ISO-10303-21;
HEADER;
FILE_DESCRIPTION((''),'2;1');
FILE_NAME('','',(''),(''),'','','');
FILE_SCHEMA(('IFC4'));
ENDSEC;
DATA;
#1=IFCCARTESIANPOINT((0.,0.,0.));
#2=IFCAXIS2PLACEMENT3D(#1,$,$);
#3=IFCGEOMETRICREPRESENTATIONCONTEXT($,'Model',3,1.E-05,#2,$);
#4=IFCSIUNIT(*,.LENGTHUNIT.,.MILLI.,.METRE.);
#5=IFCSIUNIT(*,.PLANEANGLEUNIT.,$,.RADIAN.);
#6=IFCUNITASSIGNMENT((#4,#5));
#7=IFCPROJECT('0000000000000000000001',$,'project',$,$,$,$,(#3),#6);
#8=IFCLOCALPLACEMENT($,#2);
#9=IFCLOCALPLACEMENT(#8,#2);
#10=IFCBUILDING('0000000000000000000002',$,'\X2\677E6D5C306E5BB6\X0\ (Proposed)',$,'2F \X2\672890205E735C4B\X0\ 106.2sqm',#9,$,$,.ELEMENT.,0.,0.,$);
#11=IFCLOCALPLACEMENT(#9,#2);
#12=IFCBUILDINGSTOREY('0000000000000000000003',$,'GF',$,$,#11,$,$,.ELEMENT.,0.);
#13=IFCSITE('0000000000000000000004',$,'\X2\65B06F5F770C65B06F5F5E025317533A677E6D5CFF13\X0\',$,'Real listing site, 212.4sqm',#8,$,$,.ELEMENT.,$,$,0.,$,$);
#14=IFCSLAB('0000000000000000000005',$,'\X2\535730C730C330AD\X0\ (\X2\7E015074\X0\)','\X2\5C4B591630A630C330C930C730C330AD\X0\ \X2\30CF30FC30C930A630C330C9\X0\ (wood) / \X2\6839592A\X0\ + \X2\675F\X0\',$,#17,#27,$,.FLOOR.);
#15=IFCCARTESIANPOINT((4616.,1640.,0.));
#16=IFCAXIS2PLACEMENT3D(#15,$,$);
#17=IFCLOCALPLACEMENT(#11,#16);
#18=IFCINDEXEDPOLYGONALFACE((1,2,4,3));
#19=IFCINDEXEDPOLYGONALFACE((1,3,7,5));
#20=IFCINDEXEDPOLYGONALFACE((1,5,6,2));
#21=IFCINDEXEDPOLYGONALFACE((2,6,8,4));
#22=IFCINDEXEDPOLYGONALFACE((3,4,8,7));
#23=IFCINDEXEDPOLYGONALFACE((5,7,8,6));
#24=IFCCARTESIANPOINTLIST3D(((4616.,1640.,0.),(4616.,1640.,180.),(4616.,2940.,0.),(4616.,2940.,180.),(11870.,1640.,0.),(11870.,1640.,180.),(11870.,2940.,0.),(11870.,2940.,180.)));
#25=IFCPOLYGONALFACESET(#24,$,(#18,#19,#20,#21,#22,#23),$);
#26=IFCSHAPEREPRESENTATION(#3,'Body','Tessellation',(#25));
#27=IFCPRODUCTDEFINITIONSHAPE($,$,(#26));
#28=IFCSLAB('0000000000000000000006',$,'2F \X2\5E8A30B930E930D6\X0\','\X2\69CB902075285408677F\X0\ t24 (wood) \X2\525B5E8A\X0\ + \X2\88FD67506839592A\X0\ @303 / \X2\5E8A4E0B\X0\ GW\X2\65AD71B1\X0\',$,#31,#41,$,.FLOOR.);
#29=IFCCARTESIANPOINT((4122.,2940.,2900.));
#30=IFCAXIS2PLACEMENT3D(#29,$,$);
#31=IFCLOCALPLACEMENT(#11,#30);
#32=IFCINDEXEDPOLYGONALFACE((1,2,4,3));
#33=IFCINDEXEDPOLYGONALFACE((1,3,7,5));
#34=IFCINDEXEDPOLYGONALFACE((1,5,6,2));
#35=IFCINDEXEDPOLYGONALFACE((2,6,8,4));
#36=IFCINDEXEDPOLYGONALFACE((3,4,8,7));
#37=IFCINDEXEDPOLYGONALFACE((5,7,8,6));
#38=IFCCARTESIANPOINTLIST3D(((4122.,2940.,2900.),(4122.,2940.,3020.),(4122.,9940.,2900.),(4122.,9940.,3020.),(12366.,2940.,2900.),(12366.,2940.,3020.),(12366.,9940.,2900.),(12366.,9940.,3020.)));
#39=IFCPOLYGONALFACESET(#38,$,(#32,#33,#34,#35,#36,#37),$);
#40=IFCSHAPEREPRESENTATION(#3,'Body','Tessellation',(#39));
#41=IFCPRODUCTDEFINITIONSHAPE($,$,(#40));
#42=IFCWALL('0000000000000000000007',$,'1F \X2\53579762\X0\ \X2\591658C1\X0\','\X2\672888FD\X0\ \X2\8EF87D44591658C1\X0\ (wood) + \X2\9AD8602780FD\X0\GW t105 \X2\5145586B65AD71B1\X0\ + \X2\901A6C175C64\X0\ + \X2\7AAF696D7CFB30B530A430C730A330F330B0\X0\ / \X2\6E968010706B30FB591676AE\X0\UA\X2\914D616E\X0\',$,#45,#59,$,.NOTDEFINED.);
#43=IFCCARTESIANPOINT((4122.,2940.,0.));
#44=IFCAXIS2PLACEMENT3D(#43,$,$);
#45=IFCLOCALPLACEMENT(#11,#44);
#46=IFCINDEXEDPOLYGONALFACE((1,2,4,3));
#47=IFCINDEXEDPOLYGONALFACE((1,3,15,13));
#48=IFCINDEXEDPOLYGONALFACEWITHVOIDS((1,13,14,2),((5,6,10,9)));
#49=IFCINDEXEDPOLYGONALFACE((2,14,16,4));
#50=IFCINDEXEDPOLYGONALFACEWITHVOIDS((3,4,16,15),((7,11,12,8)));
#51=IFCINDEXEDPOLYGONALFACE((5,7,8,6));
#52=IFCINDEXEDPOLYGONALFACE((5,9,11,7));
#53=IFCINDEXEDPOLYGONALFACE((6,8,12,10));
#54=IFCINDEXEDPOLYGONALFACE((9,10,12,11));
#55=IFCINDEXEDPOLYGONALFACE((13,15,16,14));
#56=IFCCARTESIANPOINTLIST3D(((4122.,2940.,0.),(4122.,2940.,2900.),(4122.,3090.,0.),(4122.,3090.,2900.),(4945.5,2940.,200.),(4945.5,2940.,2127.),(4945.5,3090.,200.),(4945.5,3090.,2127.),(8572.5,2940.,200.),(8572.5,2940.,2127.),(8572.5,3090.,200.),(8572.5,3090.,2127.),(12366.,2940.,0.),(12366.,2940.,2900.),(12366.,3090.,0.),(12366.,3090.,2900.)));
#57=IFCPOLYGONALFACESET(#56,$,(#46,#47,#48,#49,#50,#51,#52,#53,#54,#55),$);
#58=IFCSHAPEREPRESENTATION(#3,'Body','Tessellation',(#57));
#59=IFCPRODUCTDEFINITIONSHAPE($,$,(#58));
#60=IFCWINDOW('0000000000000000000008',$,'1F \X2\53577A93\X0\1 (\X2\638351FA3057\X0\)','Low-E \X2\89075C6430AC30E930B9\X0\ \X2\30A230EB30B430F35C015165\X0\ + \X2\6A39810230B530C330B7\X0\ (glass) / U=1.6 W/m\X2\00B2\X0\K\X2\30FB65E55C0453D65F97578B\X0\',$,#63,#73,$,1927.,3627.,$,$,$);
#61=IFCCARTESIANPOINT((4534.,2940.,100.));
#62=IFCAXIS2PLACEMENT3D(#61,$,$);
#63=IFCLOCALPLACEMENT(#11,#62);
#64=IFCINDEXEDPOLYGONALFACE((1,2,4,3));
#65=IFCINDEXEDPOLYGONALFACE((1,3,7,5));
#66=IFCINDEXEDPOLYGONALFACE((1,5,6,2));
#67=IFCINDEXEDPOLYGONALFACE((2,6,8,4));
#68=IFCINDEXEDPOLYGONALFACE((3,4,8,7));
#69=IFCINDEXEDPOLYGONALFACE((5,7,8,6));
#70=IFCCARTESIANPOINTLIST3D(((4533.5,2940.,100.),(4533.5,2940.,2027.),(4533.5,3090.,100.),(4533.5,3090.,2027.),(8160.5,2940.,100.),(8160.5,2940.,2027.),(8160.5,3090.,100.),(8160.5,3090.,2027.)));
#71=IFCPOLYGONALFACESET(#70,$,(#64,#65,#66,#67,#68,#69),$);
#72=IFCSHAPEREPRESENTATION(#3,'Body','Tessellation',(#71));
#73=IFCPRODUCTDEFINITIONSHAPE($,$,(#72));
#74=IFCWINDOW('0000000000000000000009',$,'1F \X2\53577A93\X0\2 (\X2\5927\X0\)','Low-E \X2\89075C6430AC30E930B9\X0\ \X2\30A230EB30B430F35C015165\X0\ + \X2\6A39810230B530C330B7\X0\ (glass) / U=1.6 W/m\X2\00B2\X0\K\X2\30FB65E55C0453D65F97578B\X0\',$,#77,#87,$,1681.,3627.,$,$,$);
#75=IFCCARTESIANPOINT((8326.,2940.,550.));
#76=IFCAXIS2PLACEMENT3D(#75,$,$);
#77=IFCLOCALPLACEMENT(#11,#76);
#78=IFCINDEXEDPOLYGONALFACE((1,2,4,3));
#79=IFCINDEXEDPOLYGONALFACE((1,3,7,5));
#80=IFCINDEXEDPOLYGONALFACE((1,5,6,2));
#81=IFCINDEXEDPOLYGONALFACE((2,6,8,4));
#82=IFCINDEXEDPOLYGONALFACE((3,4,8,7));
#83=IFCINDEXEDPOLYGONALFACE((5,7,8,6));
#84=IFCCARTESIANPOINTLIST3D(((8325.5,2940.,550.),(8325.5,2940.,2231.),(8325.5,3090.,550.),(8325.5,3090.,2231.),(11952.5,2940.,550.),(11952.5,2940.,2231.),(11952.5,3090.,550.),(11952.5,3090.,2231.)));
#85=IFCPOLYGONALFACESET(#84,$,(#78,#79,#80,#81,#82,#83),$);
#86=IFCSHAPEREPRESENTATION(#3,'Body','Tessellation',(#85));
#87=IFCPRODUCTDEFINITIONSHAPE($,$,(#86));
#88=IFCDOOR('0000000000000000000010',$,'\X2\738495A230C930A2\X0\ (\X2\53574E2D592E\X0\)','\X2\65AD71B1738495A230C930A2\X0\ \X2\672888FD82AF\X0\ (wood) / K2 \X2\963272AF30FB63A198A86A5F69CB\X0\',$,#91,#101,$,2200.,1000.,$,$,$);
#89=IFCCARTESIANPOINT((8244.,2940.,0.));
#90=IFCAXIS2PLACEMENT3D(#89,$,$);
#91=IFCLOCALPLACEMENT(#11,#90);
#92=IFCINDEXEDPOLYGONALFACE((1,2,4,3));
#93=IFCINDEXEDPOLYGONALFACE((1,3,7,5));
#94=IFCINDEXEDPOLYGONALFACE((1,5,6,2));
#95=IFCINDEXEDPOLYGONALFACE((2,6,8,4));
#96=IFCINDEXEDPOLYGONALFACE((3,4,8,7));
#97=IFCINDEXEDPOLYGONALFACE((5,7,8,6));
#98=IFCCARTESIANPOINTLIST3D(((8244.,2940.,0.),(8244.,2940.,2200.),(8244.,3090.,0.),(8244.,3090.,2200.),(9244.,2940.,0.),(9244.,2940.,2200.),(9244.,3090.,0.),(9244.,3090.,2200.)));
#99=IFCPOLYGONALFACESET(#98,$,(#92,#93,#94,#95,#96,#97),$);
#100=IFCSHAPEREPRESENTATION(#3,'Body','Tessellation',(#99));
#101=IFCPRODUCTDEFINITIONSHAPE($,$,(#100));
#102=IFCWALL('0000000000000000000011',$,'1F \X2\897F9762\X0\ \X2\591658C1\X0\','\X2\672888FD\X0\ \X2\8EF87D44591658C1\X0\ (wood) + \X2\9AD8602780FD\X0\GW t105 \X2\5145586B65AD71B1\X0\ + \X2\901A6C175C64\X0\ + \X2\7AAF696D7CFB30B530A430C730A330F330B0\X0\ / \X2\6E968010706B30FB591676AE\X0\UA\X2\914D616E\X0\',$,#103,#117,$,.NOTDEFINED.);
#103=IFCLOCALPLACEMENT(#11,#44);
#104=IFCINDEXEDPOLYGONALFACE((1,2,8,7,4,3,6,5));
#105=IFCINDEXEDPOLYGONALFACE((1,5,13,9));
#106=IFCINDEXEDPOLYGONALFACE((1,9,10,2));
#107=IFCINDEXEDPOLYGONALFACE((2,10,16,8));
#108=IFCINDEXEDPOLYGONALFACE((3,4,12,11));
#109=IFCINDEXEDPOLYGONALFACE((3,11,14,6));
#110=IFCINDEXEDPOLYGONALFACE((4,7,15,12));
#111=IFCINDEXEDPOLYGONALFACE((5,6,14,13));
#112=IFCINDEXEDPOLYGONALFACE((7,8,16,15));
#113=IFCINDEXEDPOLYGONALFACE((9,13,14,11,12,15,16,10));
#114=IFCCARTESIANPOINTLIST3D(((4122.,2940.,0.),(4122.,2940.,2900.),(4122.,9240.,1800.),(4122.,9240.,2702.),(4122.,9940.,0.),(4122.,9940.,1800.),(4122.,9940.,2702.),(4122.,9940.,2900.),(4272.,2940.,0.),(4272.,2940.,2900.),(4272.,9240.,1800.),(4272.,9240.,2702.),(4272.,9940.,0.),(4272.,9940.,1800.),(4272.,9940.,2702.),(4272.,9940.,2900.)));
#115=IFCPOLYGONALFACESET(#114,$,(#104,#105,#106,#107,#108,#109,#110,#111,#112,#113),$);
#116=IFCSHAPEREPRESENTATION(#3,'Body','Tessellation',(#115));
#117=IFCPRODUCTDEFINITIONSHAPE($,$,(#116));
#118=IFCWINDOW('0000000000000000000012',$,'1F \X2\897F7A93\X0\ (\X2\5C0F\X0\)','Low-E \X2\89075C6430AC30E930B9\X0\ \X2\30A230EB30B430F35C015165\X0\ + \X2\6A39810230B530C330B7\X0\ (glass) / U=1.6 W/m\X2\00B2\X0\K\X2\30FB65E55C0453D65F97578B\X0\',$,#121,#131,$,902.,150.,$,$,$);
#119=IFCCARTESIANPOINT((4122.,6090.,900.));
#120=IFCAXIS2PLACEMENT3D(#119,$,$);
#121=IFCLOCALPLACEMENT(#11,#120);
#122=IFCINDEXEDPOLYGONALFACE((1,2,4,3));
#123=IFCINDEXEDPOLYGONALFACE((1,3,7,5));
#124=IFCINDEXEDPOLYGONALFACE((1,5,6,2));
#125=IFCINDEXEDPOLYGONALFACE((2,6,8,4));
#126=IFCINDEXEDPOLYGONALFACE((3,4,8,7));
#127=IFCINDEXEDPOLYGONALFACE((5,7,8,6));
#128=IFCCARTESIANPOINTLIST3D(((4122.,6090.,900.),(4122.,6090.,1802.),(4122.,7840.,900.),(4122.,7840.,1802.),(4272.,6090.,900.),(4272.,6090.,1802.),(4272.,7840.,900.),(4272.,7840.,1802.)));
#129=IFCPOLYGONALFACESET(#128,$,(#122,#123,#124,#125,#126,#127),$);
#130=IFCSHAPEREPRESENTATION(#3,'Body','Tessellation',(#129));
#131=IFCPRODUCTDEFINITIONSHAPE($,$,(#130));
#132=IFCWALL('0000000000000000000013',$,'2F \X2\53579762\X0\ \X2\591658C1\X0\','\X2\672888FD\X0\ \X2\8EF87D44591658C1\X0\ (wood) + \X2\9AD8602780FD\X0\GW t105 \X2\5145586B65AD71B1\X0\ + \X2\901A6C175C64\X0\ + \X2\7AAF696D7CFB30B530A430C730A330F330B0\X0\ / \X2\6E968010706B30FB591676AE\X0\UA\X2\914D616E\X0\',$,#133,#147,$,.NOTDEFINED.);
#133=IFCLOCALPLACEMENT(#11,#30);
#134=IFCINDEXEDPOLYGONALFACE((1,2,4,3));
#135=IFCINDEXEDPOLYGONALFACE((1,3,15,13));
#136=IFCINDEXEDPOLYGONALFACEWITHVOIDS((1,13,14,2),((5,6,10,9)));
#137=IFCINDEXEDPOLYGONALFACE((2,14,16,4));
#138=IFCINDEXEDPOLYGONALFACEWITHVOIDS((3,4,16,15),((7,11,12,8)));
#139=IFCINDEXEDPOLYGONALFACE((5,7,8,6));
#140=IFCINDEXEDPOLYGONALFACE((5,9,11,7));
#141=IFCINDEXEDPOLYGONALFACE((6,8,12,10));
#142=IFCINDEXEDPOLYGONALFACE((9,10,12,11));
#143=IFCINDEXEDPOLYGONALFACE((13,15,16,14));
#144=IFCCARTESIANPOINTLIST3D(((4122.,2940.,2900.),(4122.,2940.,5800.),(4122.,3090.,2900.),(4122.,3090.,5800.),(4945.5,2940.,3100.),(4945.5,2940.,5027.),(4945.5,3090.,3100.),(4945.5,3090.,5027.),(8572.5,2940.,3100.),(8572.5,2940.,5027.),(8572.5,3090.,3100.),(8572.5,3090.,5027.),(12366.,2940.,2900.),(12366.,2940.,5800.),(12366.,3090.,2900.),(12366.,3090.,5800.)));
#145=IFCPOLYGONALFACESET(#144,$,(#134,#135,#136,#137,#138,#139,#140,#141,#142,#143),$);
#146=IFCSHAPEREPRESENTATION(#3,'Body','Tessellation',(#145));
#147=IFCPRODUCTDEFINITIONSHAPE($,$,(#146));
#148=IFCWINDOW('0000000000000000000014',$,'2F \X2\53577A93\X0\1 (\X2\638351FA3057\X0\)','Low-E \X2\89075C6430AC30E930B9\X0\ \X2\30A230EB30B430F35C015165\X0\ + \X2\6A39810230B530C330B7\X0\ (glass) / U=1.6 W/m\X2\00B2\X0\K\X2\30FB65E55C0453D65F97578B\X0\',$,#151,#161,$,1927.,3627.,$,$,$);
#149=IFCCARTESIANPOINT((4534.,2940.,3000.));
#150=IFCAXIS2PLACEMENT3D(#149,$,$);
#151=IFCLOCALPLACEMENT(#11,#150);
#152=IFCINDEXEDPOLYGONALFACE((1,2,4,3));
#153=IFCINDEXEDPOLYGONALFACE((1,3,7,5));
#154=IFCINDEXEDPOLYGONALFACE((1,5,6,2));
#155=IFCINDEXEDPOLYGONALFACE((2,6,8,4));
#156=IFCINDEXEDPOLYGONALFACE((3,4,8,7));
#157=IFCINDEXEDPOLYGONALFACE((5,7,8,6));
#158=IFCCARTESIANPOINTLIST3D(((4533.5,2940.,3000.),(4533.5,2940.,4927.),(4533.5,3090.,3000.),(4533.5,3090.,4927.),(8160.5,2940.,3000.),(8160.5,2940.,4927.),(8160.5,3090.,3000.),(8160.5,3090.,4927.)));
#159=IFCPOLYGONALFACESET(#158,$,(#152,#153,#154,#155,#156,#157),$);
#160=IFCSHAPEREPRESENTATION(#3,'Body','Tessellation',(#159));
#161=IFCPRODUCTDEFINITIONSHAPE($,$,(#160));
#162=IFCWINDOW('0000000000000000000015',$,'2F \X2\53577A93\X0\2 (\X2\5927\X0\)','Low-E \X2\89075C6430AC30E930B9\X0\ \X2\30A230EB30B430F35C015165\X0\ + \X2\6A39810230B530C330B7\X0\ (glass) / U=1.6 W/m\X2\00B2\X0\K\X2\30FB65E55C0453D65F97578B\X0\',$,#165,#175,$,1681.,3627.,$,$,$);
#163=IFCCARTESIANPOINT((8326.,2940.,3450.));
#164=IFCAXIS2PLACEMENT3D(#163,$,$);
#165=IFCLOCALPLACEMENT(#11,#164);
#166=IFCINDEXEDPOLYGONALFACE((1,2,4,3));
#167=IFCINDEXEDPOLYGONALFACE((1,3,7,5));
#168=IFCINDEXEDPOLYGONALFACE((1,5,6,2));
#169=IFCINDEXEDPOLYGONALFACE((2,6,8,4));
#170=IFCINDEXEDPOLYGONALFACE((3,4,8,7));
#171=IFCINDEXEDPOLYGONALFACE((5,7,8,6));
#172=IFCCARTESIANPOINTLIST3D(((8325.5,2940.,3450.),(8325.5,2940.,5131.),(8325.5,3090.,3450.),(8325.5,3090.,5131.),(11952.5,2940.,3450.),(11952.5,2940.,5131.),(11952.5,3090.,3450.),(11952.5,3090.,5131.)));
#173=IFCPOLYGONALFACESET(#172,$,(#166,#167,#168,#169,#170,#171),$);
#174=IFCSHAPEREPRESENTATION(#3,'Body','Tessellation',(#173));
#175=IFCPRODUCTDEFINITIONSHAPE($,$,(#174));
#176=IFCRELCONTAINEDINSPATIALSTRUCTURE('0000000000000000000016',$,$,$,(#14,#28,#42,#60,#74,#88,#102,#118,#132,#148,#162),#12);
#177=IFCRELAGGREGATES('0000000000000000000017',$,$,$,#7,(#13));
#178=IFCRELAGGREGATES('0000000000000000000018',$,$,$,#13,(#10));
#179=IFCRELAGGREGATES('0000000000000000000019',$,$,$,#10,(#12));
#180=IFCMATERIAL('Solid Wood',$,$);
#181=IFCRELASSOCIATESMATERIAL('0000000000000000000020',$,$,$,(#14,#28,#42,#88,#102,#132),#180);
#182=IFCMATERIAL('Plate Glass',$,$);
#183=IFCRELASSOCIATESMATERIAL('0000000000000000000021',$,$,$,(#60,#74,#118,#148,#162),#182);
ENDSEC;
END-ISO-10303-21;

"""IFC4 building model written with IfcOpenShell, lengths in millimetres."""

from ifc_helpers import new_model, si_unit, frame, frame_2d, origin, place, context, project, spatial, rectangle, extrude, material, element, fill, save


model = new_model("IFC4")

# Units and contexts
model_context = context("Model", 3, precision=1e-05, world=origin())
ifc_project = project(units=[si_unit("LENGTHUNIT", "METRE", prefix="MILLI"), si_unit("PLANEANGLEUNIT", "RADIAN")], contexts=[model_context])

# Site, building, storey
site_placement = place(None, origin())
site = spatial("IfcSite", under=ifc_project, at=site_placement, Name="新潟県新潟市北区松浜３", ObjectType="Real listing site, 212.4sqm", CompositionType="ELEMENT", RefElevation=0.0)
building_placement = place(site_placement, origin())
building = spatial("IfcBuilding", under=site, at=building_placement, Name="松浜の家 (Proposed)", ObjectType="2F 木造平屋 106.2sqm", CompositionType="ELEMENT", ElevationOfRefHeight=0.0, ElevationOfTerrain=0.0)
storey_placement = place(building_placement, origin())
storey = spatial("IfcBuildingStorey", under=building, at=storey_placement, Name="GF", CompositionType="ELEMENT", Elevation=0.0)

# Slabs
ifc_material_1 = material(Name="Solid Wood")
slab_1_placement = place(storey_placement, frame((4616.0, 1640.0, 0.0)))
element("IfcSlab", 1, at=slab_1_placement, inside=storey, material=ifc_material_1, Name="南デッキ (縁側)", Description="屋外ウッドデッキ ハードウッド (wood) / 根太 + 束", PredefinedType="FLOOR", context=model_context, shape_type="SweptSolid", body=[
    extrude(rectangle(XDim=7254.0, YDim=1300.0, at=frame_2d((3627.0, 650.0))), frame((4616.0, 1640.0, 0.0)), (0.0, 0.0, 1.0), 180.0),
])
slab_2_placement = place(storey_placement, frame((4122.0, 2940.0, 2900.0)))
element("IfcSlab", 2, at=slab_2_placement, inside=storey, material=ifc_material_1, Name="2F 床スラブ", Description="構造用合板 t24 (wood) 剛床 + 製材根太 @303 / 床下 GW断熱", PredefinedType="FLOOR", context=model_context, shape_type="SweptSolid", body=[
    extrude(rectangle(XDim=8244.0, YDim=7000.0, at=frame_2d((4122.0, 3500.0))), frame((4122.0, 2940.0, 2900.0)), (0.0, 0.0, 1.0), 120.0),
])

# Wall, openings, windows, door
wall_1_placement = place(storey_placement, frame((4122.0, 2940.0, 0.0)))
wall_1 = element("IfcWall", 3, at=wall_1_placement, inside=storey, material=ifc_material_1, Name="1F 南面 外壁", Description="木製 軸組外壁 (wood) + 高性能GW t105 充填断熱 + 通気層 + 窯業系サイディング / 準耐火・外皮UA配慮", PredefinedType="NOTDEFINED", context=model_context, shape_type="SweptSolid", body=[
    extrude(rectangle(XDim=8244.0, YDim=150.0, at=frame_2d((4122.0, 75.0))), frame((4122.0, 2940.0, 0.0)), (0.0, 0.0, 1.0), 2900.0),
])
opening_1_placement = place(storey_placement, frame((4534.0, 2940.0, 100.0)))
opening_1 = element("IfcOpeningElement", 4, at=opening_1_placement, cuts=wall_1, PredefinedType="NOTDEFINED", context=model_context, shape_type="SweptSolid", body=[
    extrude(rectangle(XDim=3627.0, YDim=150.0, at=frame_2d((1813.0, 75.0))), frame((4534.0, 2940.0, 100.0)), (0.0, 0.0, 1.0), 1927.0),
])
opening_2_placement = place(storey_placement, frame((8326.0, 2940.0, 550.0)))
opening_2 = element("IfcOpeningElement", 5, at=opening_2_placement, cuts=wall_1, PredefinedType="NOTDEFINED", context=model_context, shape_type="SweptSolid", body=[
    extrude(rectangle(XDim=3627.0, YDim=150.0, at=frame_2d((1813.0, 75.0))), frame((8326.0, 2940.0, 550.0)), (0.0, 0.0, 1.0), 1681.0),
])
opening_3_placement = place(storey_placement, frame((8244.0, 2940.0, 0.0)))
opening_3 = element("IfcOpeningElement", 6, at=opening_3_placement, cuts=wall_1, PredefinedType="NOTDEFINED", context=model_context, shape_type="SweptSolid", body=[
    extrude(rectangle(XDim=1000.0, YDim=150.0, at=frame_2d((500.0, 75.0))), frame((8244.0, 2940.0, 0.0)), (0.0, 0.0, 1.0), 2200.0),
])
ifc_material_2 = material(Name="Plate Glass")
window_1_placement = place(storey_placement, frame((4534.0, 2940.0, 100.0)))
window_1 = element("IfcWindow", 7, at=window_1_placement, inside=storey, material=ifc_material_2, Name="1F 南窓1 (掃出し)", Description="Low-E 複層ガラス アルゴン封入 + 樹脂サッシ (glass) / U=1.6 W/m²K・日射取得型", OverallHeight=1927.0, OverallWidth=3627.0, context=model_context, shape_type="SweptSolid", body=[
    extrude(rectangle(XDim=3627.0, YDim=150.0, at=frame_2d((1813.0, 75.0))), frame((4534.0, 2940.0, 100.0)), (0.0, 0.0, 1.0), 1927.0),
])
fill(opening_1, window_1)
window_2_placement = place(storey_placement, frame((8326.0, 2940.0, 550.0)))
window_2 = element("IfcWindow", 8, at=window_2_placement, inside=storey, material=ifc_material_2, Name="1F 南窓2 (大)", Description="Low-E 複層ガラス アルゴン封入 + 樹脂サッシ (glass) / U=1.6 W/m²K・日射取得型", OverallHeight=1681.0, OverallWidth=3627.0, context=model_context, shape_type="SweptSolid", body=[
    extrude(rectangle(XDim=3627.0, YDim=150.0, at=frame_2d((1813.0, 75.0))), frame((8326.0, 2940.0, 550.0)), (0.0, 0.0, 1.0), 1681.0),
])
fill(opening_2, window_2)
door_placement = place(storey_placement, frame((8244.0, 2940.0, 0.0)))
door = element("IfcDoor", 9, at=door_placement, inside=storey, material=ifc_material_1, Name="玄関ドア (南中央)", Description="断熱玄関ドア 木製芯 (wood) / K2 防犯・採風機構", OverallHeight=2200.0, OverallWidth=1000.0, context=model_context, shape_type="SweptSolid", body=[
    extrude(rectangle(XDim=1000.0, YDim=150.0, at=frame_2d((500.0, 75.0))), frame((8244.0, 2940.0, 0.0)), (0.0, 0.0, 1.0), 2200.0),
])
fill(opening_3, door)

# Wall, opening, window
wall_2_placement = place(storey_placement, frame((4122.0, 2940.0, 0.0)))
wall_2 = element("IfcWall", 10, at=wall_2_placement, inside=storey, material=ifc_material_1, Name="1F 西面 外壁", Description="木製 軸組外壁 (wood) + 高性能GW t105 充填断熱 + 通気層 + 窯業系サイディング / 準耐火・外皮UA配慮", PredefinedType="NOTDEFINED", context=model_context, shape_type="SweptSolid", body=[
    extrude(rectangle(XDim=150.0, YDim=7000.0, at=frame_2d((75.0, 3500.0))), frame((4122.0, 2940.0, 0.0)), (0.0, 0.0, 1.0), 2900.0),
])
opening_4_placement = place(storey_placement, frame((4122.0, 6090.0, 900.0)))
opening_4 = element("IfcOpeningElement", 11, at=opening_4_placement, cuts=wall_2, PredefinedType="NOTDEFINED", context=model_context, shape_type="SweptSolid", body=[
    extrude(rectangle(XDim=150.0, YDim=1750.0, at=frame_2d((75.0, 875.0))), frame((4122.0, 6090.0, 900.0)), (0.0, 0.0, 1.0), 902.0),
])
window_3_placement = place(storey_placement, frame((4122.0, 6090.0, 900.0)))
window_3 = element("IfcWindow", 12, at=window_3_placement, inside=storey, material=ifc_material_2, Name="1F 西窓 (小)", Description="Low-E 複層ガラス アルゴン封入 + 樹脂サッシ (glass) / U=1.6 W/m²K・日射取得型", OverallHeight=902.0, OverallWidth=150.0, context=model_context, shape_type="SweptSolid", body=[
    extrude(rectangle(XDim=150.0, YDim=1750.0, at=frame_2d((75.0, 875.0))), frame((4122.0, 6090.0, 900.0)), (0.0, 0.0, 1.0), 902.0),
])
fill(opening_4, window_3)

# Wall, openings, windows
wall_3_placement = place(storey_placement, frame((4122.0, 2940.0, 2900.0)))
wall_3 = element("IfcWall", 13, at=wall_3_placement, inside=storey, material=ifc_material_1, Name="2F 南面 外壁", Description="木製 軸組外壁 (wood) + 高性能GW t105 充填断熱 + 通気層 + 窯業系サイディング / 準耐火・外皮UA配慮", PredefinedType="NOTDEFINED", context=model_context, shape_type="SweptSolid", body=[
    extrude(rectangle(XDim=8244.0, YDim=150.0, at=frame_2d((4122.0, 75.0))), frame((4122.0, 2940.0, 2900.0)), (0.0, 0.0, 1.0), 2900.0),
])
opening_5_placement = place(storey_placement, frame((4534.0, 2940.0, 3000.0)))
opening_5 = element("IfcOpeningElement", 14, at=opening_5_placement, cuts=wall_3, PredefinedType="NOTDEFINED", context=model_context, shape_type="SweptSolid", body=[
    extrude(rectangle(XDim=3627.0, YDim=150.0, at=frame_2d((1813.0, 75.0))), frame((4534.0, 2940.0, 3000.0)), (0.0, 0.0, 1.0), 1927.0),
])
opening_6_placement = place(storey_placement, frame((8326.0, 2940.0, 3450.0)))
opening_6 = element("IfcOpeningElement", 15, at=opening_6_placement, cuts=wall_3, PredefinedType="NOTDEFINED", context=model_context, shape_type="SweptSolid", body=[
    extrude(rectangle(XDim=3627.0, YDim=150.0, at=frame_2d((1813.0, 75.0))), frame((8326.0, 2940.0, 3450.0)), (0.0, 0.0, 1.0), 1681.0),
])
window_4_placement = place(storey_placement, frame((4534.0, 2940.0, 3000.0)))
window_4 = element("IfcWindow", 16, at=window_4_placement, inside=storey, material=ifc_material_2, Name="2F 南窓1 (掃出し)", Description="Low-E 複層ガラス アルゴン封入 + 樹脂サッシ (glass) / U=1.6 W/m²K・日射取得型", OverallHeight=1927.0, OverallWidth=3627.0, context=model_context, shape_type="SweptSolid", body=[
    extrude(rectangle(XDim=3627.0, YDim=150.0, at=frame_2d((1813.0, 75.0))), frame((4534.0, 2940.0, 3000.0)), (0.0, 0.0, 1.0), 1927.0),
])
fill(opening_5, window_4)
window_5_placement = place(storey_placement, frame((8326.0, 2940.0, 3450.0)))
window_5 = element("IfcWindow", 17, at=window_5_placement, inside=storey, material=ifc_material_2, Name="2F 南窓2 (大)", Description="Low-E 複層ガラス アルゴン封入 + 樹脂サッシ (glass) / U=1.6 W/m²K・日射取得型", OverallHeight=1681.0, OverallWidth=3627.0, context=model_context, shape_type="SweptSolid", body=[
    extrude(rectangle(XDim=3627.0, YDim=150.0, at=frame_2d((1813.0, 75.0))), frame((8326.0, 2940.0, 3450.0)), (0.0, 0.0, 1.0), 1681.0),
])
fill(opening_6, window_5)

save(model, "model.ifc")
